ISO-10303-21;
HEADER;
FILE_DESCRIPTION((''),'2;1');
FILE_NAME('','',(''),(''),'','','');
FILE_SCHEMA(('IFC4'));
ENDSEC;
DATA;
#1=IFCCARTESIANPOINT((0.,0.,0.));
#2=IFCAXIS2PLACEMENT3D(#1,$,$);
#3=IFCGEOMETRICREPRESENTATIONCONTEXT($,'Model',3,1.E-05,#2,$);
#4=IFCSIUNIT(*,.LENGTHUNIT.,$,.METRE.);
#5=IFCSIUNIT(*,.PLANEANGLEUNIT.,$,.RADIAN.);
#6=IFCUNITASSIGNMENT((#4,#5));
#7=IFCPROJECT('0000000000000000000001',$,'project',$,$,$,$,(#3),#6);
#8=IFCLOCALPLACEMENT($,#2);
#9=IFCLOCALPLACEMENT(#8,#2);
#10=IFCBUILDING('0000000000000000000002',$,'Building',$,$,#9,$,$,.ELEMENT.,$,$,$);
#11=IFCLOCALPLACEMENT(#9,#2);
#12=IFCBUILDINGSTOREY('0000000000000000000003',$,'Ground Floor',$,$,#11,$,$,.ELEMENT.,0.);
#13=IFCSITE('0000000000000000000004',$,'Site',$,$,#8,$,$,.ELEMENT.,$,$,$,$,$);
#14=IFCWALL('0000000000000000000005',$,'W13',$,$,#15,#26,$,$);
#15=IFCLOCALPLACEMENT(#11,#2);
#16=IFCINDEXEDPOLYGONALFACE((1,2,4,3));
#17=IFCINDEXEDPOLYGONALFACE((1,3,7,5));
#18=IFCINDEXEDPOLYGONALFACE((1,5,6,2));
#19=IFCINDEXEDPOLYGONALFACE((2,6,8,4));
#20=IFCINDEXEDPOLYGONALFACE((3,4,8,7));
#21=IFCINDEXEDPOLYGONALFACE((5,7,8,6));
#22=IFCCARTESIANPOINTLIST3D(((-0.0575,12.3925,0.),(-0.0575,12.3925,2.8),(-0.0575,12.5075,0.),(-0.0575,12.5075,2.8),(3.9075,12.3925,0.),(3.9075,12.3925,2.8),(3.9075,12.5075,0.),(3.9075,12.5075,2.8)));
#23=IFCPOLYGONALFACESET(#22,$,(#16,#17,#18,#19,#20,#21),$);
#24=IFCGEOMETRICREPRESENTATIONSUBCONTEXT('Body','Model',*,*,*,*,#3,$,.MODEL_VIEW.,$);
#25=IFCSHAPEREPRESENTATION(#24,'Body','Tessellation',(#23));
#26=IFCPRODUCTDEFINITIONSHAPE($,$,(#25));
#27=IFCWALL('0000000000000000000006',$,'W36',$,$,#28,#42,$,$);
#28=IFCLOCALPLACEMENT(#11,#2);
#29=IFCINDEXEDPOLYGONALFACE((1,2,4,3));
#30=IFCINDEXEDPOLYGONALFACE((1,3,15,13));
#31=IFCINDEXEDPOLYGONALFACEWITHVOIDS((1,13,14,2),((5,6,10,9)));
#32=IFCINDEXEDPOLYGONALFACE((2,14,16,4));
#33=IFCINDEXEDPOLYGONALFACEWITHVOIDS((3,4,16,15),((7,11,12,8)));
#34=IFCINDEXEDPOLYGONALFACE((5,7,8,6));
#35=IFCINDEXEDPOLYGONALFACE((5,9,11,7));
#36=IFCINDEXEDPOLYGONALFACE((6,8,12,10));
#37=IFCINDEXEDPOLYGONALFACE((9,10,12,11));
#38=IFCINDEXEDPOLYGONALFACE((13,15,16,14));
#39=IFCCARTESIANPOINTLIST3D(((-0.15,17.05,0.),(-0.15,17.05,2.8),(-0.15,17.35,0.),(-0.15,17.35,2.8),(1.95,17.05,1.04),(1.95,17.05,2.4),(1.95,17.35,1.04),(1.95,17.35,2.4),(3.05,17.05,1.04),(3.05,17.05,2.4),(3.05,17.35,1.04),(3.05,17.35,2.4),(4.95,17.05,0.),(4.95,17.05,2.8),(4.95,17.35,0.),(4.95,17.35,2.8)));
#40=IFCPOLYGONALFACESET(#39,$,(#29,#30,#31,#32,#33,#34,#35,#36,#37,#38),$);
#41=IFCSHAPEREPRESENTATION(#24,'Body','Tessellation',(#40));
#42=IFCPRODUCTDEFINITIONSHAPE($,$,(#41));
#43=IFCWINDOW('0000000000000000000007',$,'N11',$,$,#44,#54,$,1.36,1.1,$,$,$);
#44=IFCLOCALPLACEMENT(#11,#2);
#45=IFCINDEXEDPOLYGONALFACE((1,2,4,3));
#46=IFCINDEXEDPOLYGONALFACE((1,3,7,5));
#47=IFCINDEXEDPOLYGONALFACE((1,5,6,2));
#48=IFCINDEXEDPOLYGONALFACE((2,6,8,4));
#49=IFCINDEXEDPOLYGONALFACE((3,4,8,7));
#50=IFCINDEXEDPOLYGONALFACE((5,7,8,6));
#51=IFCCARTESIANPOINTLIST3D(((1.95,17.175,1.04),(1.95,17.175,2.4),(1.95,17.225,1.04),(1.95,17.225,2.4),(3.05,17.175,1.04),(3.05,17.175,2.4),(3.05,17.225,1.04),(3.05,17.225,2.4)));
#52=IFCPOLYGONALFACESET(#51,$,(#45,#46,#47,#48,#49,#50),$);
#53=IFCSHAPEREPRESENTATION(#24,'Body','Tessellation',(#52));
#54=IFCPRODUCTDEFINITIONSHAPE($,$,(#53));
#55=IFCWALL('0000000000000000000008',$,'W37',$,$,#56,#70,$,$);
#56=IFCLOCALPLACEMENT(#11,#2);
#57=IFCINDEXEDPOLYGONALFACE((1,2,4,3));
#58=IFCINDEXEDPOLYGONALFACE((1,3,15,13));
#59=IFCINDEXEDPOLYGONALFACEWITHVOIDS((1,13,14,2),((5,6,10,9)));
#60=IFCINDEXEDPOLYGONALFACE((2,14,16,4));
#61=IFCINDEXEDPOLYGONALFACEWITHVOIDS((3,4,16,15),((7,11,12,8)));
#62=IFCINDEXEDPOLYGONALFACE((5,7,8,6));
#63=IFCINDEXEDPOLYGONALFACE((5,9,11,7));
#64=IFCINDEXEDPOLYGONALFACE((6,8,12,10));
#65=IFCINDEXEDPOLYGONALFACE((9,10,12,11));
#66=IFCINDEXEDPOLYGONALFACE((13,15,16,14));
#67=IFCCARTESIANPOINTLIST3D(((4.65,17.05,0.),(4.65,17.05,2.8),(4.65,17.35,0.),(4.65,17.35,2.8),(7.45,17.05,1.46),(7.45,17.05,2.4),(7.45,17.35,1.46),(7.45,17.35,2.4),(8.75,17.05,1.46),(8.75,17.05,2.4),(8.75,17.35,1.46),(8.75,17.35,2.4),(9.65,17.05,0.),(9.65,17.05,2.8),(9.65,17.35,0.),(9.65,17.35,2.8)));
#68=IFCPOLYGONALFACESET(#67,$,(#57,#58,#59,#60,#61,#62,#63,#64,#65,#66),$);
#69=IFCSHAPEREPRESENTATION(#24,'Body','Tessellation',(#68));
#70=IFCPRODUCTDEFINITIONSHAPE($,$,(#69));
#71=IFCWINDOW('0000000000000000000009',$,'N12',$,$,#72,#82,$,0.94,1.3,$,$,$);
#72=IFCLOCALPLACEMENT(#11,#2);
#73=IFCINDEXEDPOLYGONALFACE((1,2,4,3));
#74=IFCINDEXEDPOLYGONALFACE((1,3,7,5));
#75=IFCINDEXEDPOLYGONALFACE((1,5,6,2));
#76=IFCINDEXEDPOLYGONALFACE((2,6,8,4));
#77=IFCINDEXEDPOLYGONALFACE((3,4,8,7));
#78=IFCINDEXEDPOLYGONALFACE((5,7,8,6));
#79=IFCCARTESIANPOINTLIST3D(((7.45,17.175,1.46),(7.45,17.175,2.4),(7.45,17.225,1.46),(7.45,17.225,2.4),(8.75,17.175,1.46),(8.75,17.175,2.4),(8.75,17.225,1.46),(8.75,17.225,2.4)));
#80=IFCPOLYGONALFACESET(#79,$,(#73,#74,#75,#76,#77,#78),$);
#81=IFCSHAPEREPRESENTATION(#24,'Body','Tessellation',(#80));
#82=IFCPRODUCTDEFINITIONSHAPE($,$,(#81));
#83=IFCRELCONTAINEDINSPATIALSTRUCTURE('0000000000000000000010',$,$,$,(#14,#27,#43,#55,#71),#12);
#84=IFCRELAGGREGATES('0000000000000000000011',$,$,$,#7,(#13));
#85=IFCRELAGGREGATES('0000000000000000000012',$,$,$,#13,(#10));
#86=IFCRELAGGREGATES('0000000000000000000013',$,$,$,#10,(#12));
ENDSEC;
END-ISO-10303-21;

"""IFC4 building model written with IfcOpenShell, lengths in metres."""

from ifc_helpers import new_model, si_unit, frame, frame_2d, origin, origin_2d, place, context, subcontext, project, spatial, rectangle, extrude, element, fill, save


model = new_model("IFC4")

# Units and contexts
model_context = context("Model", 3, precision=1e-05, world=origin())
body_context = subcontext(model_context, "Body", "Model", "MODEL_VIEW")
ifc_project = project(units=[si_unit("LENGTHUNIT", "METRE"), si_unit("PLANEANGLEUNIT", "RADIAN")], contexts=[model_context])

# Site, building, storey
site_placement = place(None, origin())
site = spatial("IfcSite", under=ifc_project, at=site_placement, Name="Site", CompositionType="ELEMENT")
building_placement = place(site_placement, origin())
building = spatial("IfcBuilding", under=site, at=building_placement, Name="Building", CompositionType="ELEMENT")
storey_placement = place(building_placement, origin())
storey = spatial("IfcBuildingStorey", under=building, at=storey_placement, Name="Ground Floor", CompositionType="ELEMENT", Elevation=0.0)

# Wall
wall_1_placement = place(storey_placement, frame((0.0, 12.45, 0.0), x_axis=(1.0, 0.0, 0.0)))
element("IfcWall", 1, at=wall_1_placement, inside=storey, Name="W13", context=body_context, shape_type="SweptSolid", body=[
    extrude(rectangle(XDim=3.965, YDim=0.115, at=frame_2d((1.925, 0.0))), origin(), (0.0, 0.0, 1.0), 2.8),
])

# Walls, openings, windows
wall_2_placement = place(storey_placement, frame((0.0, 17.2, 0.0), x_axis=(1.0, 0.0, 0.0)))
wall_2 = element("IfcWall", 2, at=wall_2_placement, inside=storey, Name="W36", context=body_context, shape_type="SweptSolid", body=[
    extrude(rectangle(XDim=5.1, YDim=0.3, at=frame_2d((2.4, 0.0))), origin(), (0.0, 0.0, 1.0), 2.8),
])
opening_1_placement = place(wall_2_placement, frame((2.5, 0.0, 1.04)))
opening_1 = element("IfcOpeningElement", 3, at=opening_1_placement, cuts=wall_2, context=body_context, shape_type="SweptSolid", body=[
    extrude(rectangle(XDim=1.1, YDim=0.4, at=origin_2d()), origin(), (0.0, 0.0, 1.0), 1.36),
])
window_1_placement = place(opening_1_placement, origin())
window_1 = element("IfcWindow", 4, at=window_1_placement, inside=storey, Name="N11", OverallHeight=1.36, OverallWidth=1.1, context=body_context, shape_type="SweptSolid", body=[
    extrude(rectangle(XDim=1.1, YDim=0.05, at=origin_2d()), origin(), (0.0, 0.0, 1.0), 1.36),
])
fill(opening_1, window_1)
wall_3_placement = place(storey_placement, frame((4.8, 17.2, 0.0), x_axis=(1.0, 0.0, 0.0)))
wall_3 = element("IfcWall", 5, at=wall_3_placement, inside=storey, Name="W37", context=body_context, shape_type="SweptSolid", body=[
    extrude(rectangle(XDim=5.0, YDim=0.3, at=frame_2d((2.35, 0.0))), origin(), (0.0, 0.0, 1.0), 2.8),
])
opening_2_placement = place(wall_3_placement, frame((3.3, 0.0, 1.46)))
opening_2 = element("IfcOpeningElement", 6, at=opening_2_placement, cuts=wall_3, context=body_context, shape_type="SweptSolid", body=[
    extrude(rectangle(XDim=1.3, YDim=0.4, at=origin_2d()), origin(), (0.0, 0.0, 1.0), 0.94),
])
window_2_placement = place(opening_2_placement, origin())
window_2 = element("IfcWindow", 7, at=window_2_placement, inside=storey, Name="N12", OverallHeight=0.94, OverallWidth=1.3, context=body_context, shape_type="SweptSolid", body=[
    extrude(rectangle(XDim=1.3, YDim=0.05, at=origin_2d()), origin(), (0.0, 0.0, 1.0), 0.94),
])
fill(opening_2, window_2)

save(model, "model.ifc")
